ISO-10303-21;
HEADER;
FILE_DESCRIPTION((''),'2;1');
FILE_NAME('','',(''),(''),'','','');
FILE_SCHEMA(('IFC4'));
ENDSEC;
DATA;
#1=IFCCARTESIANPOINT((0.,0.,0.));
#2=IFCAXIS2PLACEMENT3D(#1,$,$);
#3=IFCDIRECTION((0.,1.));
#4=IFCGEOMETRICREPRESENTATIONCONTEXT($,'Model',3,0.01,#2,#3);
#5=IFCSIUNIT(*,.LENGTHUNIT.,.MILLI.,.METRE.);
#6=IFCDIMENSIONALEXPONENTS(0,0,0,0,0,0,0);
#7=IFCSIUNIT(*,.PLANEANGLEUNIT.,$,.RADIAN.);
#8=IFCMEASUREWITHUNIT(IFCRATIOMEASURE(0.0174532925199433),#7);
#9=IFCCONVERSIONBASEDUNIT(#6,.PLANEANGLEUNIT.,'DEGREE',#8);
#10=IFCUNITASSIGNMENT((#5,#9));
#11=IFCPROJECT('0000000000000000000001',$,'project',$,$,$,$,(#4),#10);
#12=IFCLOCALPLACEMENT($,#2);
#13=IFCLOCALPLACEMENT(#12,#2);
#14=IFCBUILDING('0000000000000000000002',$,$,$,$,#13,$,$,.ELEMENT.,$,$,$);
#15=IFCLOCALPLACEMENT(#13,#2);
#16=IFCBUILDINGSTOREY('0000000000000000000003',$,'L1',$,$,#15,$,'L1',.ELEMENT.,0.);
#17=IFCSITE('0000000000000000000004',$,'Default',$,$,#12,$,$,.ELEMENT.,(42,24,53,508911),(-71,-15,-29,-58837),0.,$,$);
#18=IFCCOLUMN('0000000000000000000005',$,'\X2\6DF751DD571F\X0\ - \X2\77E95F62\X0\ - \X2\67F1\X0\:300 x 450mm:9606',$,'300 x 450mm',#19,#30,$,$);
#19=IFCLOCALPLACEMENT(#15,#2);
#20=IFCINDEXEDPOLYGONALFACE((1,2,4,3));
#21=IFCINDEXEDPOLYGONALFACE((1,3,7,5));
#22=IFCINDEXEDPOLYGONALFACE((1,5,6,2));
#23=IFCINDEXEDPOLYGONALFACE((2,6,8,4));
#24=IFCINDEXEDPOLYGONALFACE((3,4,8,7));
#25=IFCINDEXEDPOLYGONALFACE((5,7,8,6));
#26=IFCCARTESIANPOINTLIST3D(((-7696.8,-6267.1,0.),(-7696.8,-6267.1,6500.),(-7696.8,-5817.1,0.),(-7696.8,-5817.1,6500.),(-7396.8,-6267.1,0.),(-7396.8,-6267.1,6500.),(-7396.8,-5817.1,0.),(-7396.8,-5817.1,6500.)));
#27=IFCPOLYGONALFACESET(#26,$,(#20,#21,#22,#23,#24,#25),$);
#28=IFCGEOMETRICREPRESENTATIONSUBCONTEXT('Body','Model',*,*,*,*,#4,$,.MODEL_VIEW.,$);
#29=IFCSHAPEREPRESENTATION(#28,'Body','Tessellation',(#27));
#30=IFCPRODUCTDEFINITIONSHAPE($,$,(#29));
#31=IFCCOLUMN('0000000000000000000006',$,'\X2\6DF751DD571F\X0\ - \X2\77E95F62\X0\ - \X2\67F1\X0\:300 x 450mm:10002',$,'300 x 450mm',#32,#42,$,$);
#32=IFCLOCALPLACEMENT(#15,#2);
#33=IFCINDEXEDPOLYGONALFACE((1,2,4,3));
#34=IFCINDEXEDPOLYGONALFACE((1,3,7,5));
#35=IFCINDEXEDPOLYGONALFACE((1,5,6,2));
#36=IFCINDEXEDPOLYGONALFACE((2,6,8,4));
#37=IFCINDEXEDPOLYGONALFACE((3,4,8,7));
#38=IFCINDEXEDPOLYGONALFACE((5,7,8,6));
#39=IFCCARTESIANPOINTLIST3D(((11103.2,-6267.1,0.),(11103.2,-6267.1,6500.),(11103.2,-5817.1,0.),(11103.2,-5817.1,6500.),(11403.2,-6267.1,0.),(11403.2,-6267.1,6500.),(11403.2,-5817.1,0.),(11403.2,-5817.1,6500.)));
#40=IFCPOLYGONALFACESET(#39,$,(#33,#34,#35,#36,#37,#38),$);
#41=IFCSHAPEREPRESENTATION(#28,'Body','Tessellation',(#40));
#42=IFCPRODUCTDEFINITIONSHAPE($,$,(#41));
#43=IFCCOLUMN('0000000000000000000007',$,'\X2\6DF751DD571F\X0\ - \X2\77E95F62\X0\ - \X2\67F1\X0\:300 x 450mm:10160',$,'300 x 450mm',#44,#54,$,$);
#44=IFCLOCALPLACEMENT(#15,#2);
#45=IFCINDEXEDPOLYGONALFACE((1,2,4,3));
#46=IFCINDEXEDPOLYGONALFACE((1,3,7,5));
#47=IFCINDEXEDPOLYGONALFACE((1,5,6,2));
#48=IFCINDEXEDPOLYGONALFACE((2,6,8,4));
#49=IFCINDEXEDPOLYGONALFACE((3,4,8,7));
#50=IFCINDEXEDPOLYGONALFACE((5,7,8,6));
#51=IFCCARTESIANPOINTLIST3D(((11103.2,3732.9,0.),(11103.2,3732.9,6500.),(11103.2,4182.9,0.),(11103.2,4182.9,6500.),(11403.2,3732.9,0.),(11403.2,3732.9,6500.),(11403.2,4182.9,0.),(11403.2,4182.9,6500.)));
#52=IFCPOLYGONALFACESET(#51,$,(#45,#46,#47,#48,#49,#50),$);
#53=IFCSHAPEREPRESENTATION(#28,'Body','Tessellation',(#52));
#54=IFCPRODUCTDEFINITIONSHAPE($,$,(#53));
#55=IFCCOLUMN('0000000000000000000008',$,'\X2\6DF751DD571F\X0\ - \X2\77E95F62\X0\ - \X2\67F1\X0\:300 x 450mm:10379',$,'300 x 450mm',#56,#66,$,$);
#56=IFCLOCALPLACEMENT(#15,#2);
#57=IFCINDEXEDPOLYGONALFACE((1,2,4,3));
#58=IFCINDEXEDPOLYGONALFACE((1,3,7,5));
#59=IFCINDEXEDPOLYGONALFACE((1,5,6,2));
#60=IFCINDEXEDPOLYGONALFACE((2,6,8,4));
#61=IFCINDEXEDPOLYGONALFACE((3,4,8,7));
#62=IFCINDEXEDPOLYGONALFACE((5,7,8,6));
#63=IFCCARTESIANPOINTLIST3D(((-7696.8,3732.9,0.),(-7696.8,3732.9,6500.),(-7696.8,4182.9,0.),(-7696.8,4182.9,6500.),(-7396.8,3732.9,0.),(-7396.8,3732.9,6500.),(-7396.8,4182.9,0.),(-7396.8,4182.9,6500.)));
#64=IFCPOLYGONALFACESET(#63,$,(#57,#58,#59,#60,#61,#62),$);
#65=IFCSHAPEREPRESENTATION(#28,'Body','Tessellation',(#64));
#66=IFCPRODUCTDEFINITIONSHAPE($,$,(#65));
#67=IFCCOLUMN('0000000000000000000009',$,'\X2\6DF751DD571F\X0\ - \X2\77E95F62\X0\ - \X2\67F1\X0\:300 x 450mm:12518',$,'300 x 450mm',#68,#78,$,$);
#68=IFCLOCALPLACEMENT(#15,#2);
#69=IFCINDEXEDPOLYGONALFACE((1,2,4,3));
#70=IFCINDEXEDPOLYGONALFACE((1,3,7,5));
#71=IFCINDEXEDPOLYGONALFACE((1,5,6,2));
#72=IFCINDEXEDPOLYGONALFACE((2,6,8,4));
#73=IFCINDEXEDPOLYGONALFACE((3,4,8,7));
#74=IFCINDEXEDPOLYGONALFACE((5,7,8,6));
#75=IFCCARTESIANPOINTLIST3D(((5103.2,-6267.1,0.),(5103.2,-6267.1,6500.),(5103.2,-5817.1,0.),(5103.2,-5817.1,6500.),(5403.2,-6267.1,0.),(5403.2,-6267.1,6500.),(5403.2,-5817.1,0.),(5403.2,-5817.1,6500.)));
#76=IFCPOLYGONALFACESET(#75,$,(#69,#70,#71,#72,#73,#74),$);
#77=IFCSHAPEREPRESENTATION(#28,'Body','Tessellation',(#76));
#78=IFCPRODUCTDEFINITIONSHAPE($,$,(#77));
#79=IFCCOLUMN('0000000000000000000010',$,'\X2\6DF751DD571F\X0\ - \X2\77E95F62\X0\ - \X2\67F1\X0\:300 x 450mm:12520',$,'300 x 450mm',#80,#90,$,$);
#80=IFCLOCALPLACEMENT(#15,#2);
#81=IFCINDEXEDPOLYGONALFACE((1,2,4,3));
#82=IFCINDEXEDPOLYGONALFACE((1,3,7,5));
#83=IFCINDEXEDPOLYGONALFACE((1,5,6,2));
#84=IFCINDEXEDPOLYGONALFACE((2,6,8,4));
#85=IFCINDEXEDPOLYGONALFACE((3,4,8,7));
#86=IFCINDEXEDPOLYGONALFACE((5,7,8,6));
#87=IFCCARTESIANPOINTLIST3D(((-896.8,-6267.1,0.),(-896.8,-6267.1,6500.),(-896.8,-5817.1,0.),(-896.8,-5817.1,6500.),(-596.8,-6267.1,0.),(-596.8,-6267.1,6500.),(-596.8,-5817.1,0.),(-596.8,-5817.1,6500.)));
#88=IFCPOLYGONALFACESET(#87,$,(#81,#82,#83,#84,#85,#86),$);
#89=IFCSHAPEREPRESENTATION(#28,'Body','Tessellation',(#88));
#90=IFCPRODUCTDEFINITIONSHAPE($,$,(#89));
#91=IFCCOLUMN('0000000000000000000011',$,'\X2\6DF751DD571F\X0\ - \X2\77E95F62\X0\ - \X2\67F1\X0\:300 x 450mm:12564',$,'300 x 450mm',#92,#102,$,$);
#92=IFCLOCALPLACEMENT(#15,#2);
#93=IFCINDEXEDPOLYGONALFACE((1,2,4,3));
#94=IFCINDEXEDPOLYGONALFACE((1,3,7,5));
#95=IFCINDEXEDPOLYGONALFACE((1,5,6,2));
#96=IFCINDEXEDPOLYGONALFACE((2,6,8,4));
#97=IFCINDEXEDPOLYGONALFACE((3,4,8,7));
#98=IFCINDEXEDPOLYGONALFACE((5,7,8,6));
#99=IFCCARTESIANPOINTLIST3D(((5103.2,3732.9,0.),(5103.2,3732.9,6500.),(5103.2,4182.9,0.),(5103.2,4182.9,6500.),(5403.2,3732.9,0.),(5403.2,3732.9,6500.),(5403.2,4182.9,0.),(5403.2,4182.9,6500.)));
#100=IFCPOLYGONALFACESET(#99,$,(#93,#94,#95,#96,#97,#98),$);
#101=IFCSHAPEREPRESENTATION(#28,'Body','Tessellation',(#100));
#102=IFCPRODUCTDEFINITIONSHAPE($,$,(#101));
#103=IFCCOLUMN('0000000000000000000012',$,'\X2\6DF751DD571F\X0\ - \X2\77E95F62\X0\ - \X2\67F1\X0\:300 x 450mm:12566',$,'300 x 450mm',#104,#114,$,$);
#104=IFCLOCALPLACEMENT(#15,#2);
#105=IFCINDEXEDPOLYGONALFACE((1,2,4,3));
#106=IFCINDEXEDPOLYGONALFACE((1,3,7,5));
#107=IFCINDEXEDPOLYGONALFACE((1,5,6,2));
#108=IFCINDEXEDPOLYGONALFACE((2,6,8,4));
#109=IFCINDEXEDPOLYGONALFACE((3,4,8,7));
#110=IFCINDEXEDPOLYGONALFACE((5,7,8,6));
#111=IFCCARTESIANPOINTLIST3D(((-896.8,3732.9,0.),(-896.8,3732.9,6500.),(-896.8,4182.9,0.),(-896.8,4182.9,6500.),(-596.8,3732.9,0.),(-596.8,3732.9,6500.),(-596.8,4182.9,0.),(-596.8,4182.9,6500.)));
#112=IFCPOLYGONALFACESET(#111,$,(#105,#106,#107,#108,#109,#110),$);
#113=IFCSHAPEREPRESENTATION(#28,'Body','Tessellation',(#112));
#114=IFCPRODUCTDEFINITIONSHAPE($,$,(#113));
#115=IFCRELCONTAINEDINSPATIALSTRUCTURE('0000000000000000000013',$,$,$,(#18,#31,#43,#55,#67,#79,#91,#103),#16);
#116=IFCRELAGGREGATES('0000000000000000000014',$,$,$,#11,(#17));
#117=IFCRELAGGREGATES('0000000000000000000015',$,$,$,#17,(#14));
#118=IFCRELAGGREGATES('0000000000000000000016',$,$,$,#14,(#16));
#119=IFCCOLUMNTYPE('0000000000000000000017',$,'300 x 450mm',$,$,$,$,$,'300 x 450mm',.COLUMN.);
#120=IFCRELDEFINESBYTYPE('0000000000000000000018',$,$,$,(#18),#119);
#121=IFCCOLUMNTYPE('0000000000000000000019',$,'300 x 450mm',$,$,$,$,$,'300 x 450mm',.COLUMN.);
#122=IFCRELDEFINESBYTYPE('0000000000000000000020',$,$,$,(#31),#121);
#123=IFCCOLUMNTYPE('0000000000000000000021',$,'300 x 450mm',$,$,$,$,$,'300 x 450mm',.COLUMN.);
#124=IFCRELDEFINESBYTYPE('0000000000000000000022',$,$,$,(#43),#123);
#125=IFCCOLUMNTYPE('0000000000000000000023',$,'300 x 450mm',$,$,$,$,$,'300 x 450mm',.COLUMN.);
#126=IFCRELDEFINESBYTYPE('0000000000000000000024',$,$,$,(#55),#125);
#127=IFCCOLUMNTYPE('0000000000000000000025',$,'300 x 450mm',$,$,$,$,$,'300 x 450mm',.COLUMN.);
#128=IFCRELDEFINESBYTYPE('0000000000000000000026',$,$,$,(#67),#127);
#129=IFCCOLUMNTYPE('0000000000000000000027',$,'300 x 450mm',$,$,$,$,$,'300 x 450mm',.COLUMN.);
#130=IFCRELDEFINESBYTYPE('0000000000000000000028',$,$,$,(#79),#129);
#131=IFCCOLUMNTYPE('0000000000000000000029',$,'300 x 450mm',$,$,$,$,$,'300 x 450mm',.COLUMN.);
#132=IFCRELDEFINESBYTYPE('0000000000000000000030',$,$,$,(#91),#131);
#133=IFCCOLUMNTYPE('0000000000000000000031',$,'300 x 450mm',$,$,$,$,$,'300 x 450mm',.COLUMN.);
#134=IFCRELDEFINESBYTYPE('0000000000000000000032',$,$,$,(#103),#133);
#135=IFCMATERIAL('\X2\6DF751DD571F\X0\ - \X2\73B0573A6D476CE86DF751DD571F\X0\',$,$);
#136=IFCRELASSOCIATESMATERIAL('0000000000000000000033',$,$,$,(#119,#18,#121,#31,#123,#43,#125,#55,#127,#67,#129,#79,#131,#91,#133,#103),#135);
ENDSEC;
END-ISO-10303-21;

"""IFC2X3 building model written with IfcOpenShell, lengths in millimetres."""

from ifc_helpers import new_model, entity, si_unit, converted_unit, direction, frame, frame_2d, origin, origin_2d_with_axis, place, context, subcontext, project, spatial, rectangle, extrude, source, transform, mapped, material, type_object, type_shapes, element, save


model = new_model("IFC2X3")

# Units and contexts
model_context = context("Model", 3, precision=0.01, world=origin(), true_north=direction((0.0, 1.0)))
body_context = subcontext(model_context, "Body", "Model", "MODEL_VIEW")
ifc_project = project(units=[si_unit("LENGTHUNIT", "METRE", prefix="MILLI"), converted_unit("PLANEANGLEUNIT", "DEGREE", entity("IfcRatioMeasure", 0.0174532925199433), si_unit("PLANEANGLEUNIT", "RADIAN"), dimensions=[0, 0, 0, 0, 0, 0, 0])], contexts=[model_context])

# Site, building, storey
site_placement = place(None, origin())
site = spatial("IfcSite", under=ifc_project, at=site_placement, Name="Default", CompositionType="ELEMENT", RefLatitude=(42, 24, 53, 508911), RefLongitude=(-71, -15, -29, -58837), RefElevation=0.0)
building_placement = place(site_placement, origin())
building = spatial("IfcBuilding", under=site, at=building_placement, CompositionType="ELEMENT")
storey_placement = place(building_placement, origin())
storey = spatial("IfcBuildingStorey", under=building, at=storey_placement, Name="L1", LongName="L1", CompositionType="ELEMENT", Elevation=0.0)

# Columns
ifc_material = material(Name="混凝土 - 现场浇注混凝土")
column_type_1 = type_object("IfcColumnType", Name="300 x 450mm", ElementType="300 x 450mm", PredefinedType="COLUMN", material=ifc_material)
shared_shape_1 = source(origin(), body_context, "Body", "SweptSolid", [
    extrude(rectangle(XDim=450.0, YDim=300.0, at=frame_2d((0.0, 0.0), x_axis=(1.0, 0.0))), frame((-7546.8, -6042.1, 0.0), z_axis=(0.0, 0.0, 1.0), x_axis=(0.0, -1.0, 0.0)), (0.0, 0.0, 1.0), 6500.0),
])
type_shapes(column_type_1, [shared_shape_1])
column_1_placement = place(storey_placement, origin())
element("IfcColumn", 1, at=column_1_placement, inside=storey, type_object=column_type_1, material=ifc_material, Name="混凝土 - 矩形 - 柱:300 x 450mm:9606", ObjectType="300 x 450mm", context=body_context, shape_type="MappedRepresentation", body=[
    mapped(shared_shape_1, transform((0.0, 0.0, 0.0), scale=1.0)),
])
column_type_2 = type_object("IfcColumnType", Name="300 x 450mm", ElementType="300 x 450mm", PredefinedType="COLUMN", material=ifc_material)
shared_shape_2 = source(origin(), body_context, "Body", "SweptSolid", [
    extrude(rectangle(XDim=450.0, YDim=300.0, at=origin_2d_with_axis()), frame((11253.2, -6042.1, 0.0), z_axis=(0.0, 0.0, 1.0), x_axis=(0.0, -1.0, 0.0)), (0.0, 0.0, 1.0), 6500.0),
])
type_shapes(column_type_2, [shared_shape_2])
column_2_placement = place(storey_placement, origin())
element("IfcColumn", 2, at=column_2_placement, inside=storey, type_object=column_type_2, material=ifc_material, Name="混凝土 - 矩形 - 柱:300 x 450mm:10002", ObjectType="300 x 450mm", context=body_context, shape_type="MappedRepresentation", body=[
    mapped(shared_shape_2, transform((0.0, 0.0, 0.0), scale=1.0)),
])
column_type_3 = type_object("IfcColumnType", Name="300 x 450mm", ElementType="300 x 450mm", PredefinedType="COLUMN", material=ifc_material)
shared_shape_3 = source(origin(), body_context, "Body", "SweptSolid", [
    extrude(rectangle(XDim=450.0, YDim=300.0, at=frame_2d((0.0, 0.0), x_axis=(1.0, 0.0))), frame((11253.2, 3957.9, 0.0), z_axis=(0.0, 0.0, 1.0), x_axis=(0.0, -1.0, 0.0)), (0.0, 0.0, 1.0), 6500.0),
])
type_shapes(column_type_3, [shared_shape_3])
column_3_placement = place(storey_placement, origin())
element("IfcColumn", 3, at=column_3_placement, inside=storey, type_object=column_type_3, material=ifc_material, Name="混凝土 - 矩形 - 柱:300 x 450mm:10160", ObjectType="300 x 450mm", context=body_context, shape_type="MappedRepresentation", body=[
    mapped(shared_shape_3, transform((0.0, 0.0, 0.0), scale=1.0)),
])
column_type_4 = type_object("IfcColumnType", Name="300 x 450mm", ElementType="300 x 450mm", PredefinedType="COLUMN", material=ifc_material)
shared_shape_4 = source(origin(), body_context, "Body", "SweptSolid", [
    extrude(rectangle(XDim=450.0, YDim=300.0, at=frame_2d((0.0, 0.0), x_axis=(1.0, 0.0))), frame((-7546.8, 3957.9, 0.0), z_axis=(0.0, 0.0, 1.0), x_axis=(0.0, -1.0, 0.0)), (0.0, 0.0, 1.0), 6500.0),
])
type_shapes(column_type_4, [shared_shape_4])
column_4_placement = place(storey_placement, origin())
element("IfcColumn", 4, at=column_4_placement, inside=storey, type_object=column_type_4, material=ifc_material, Name="混凝土 - 矩形 - 柱:300 x 450mm:10379", ObjectType="300 x 450mm", context=body_context, shape_type="MappedRepresentation", body=[
    mapped(shared_shape_4, transform((0.0, 0.0, 0.0), scale=1.0)),
])
column_type_5 = type_object("IfcColumnType", Name="300 x 450mm", ElementType="300 x 450mm", PredefinedType="COLUMN", material=ifc_material)
shared_shape_5 = source(origin(), body_context, "Body", "SweptSolid", [
    extrude(rectangle(XDim=450.0, YDim=300.0, at=frame_2d((0.0, 0.0), x_axis=(1.0, 0.0))), frame((5253.2, -6042.1, 0.0), z_axis=(0.0, 0.0, 1.0), x_axis=(0.0, -1.0, 0.0)), (0.0, 0.0, 1.0), 6500.0),
])
type_shapes(column_type_5, [shared_shape_5])
column_5_placement = place(storey_placement, origin())
element("IfcColumn", 5, at=column_5_placement, inside=storey, type_object=column_type_5, material=ifc_material, Name="混凝土 - 矩形 - 柱:300 x 450mm:12518", ObjectType="300 x 450mm", context=body_context, shape_type="MappedRepresentation", body=[
    mapped(shared_shape_5, transform((0.0, 0.0, 0.0), scale=1.0)),
])
column_type_6 = type_object("IfcColumnType", Name="300 x 450mm", ElementType="300 x 450mm", PredefinedType="COLUMN", material=ifc_material)
shared_shape_6 = source(origin(), body_context, "Body", "SweptSolid", [
    extrude(rectangle(XDim=450.0, YDim=300.0, at=origin_2d_with_axis()), frame((-746.8, -6042.1, 0.0), z_axis=(0.0, 0.0, 1.0), x_axis=(0.0, -1.0, 0.0)), (0.0, 0.0, 1.0), 6500.0),
])
type_shapes(column_type_6, [shared_shape_6])
column_6_placement = place(storey_placement, origin())
element("IfcColumn", 6, at=column_6_placement, inside=storey, type_object=column_type_6, material=ifc_material, Name="混凝土 - 矩形 - 柱:300 x 450mm:12520", ObjectType="300 x 450mm", context=body_context, shape_type="MappedRepresentation", body=[
    mapped(shared_shape_6, transform((0.0, 0.0, 0.0), scale=1.0)),
])
column_type_7 = type_object("IfcColumnType", Name="300 x 450mm", ElementType="300 x 450mm", PredefinedType="COLUMN", material=ifc_material)
shared_shape_7 = source(origin(), body_context, "Body", "SweptSolid", [
    extrude(rectangle(XDim=450.0, YDim=300.0, at=frame_2d((0.0, 0.0), x_axis=(1.0, 0.0))), frame((5253.2, 3957.9, 0.0), z_axis=(0.0, 0.0, 1.0), x_axis=(0.0, -1.0, 0.0)), (0.0, 0.0, 1.0), 6500.0),
])
type_shapes(column_type_7, [shared_shape_7])
column_7_placement = place(storey_placement, origin())
element("IfcColumn", 7, at=column_7_placement, inside=storey, type_object=column_type_7, material=ifc_material, Name="混凝土 - 矩形 - 柱:300 x 450mm:12564", ObjectType="300 x 450mm", context=body_context, shape_type="MappedRepresentation", body=[
    mapped(shared_shape_7, transform((0.0, 0.0, 0.0), scale=1.0)),
])
column_type_8 = type_object("IfcColumnType", Name="300 x 450mm", ElementType="300 x 450mm", PredefinedType="COLUMN", material=ifc_material)
shared_shape_8 = source(origin(), body_context, "Body", "SweptSolid", [
    extrude(rectangle(XDim=450.0, YDim=300.0, at=frame_2d((0.0, 0.0), x_axis=(1.0, 0.0))), frame((-746.8, 3957.9, 0.0), z_axis=(0.0, 0.0, 1.0), x_axis=(0.0, -1.0, 0.0)), (0.0, 0.0, 1.0), 6500.0),
])
type_shapes(column_type_8, [shared_shape_8])
column_8_placement = place(storey_placement, origin())
element("IfcColumn", 8, at=column_8_placement, inside=storey, type_object=column_type_8, material=ifc_material, Name="混凝土 - 矩形 - 柱:300 x 450mm:12566", ObjectType="300 x 450mm", context=body_context, shape_type="MappedRepresentation", body=[
    mapped(shared_shape_8, transform((0.0, 0.0, 0.0), scale=1.0)),
])

save(model, "model.ifc")
